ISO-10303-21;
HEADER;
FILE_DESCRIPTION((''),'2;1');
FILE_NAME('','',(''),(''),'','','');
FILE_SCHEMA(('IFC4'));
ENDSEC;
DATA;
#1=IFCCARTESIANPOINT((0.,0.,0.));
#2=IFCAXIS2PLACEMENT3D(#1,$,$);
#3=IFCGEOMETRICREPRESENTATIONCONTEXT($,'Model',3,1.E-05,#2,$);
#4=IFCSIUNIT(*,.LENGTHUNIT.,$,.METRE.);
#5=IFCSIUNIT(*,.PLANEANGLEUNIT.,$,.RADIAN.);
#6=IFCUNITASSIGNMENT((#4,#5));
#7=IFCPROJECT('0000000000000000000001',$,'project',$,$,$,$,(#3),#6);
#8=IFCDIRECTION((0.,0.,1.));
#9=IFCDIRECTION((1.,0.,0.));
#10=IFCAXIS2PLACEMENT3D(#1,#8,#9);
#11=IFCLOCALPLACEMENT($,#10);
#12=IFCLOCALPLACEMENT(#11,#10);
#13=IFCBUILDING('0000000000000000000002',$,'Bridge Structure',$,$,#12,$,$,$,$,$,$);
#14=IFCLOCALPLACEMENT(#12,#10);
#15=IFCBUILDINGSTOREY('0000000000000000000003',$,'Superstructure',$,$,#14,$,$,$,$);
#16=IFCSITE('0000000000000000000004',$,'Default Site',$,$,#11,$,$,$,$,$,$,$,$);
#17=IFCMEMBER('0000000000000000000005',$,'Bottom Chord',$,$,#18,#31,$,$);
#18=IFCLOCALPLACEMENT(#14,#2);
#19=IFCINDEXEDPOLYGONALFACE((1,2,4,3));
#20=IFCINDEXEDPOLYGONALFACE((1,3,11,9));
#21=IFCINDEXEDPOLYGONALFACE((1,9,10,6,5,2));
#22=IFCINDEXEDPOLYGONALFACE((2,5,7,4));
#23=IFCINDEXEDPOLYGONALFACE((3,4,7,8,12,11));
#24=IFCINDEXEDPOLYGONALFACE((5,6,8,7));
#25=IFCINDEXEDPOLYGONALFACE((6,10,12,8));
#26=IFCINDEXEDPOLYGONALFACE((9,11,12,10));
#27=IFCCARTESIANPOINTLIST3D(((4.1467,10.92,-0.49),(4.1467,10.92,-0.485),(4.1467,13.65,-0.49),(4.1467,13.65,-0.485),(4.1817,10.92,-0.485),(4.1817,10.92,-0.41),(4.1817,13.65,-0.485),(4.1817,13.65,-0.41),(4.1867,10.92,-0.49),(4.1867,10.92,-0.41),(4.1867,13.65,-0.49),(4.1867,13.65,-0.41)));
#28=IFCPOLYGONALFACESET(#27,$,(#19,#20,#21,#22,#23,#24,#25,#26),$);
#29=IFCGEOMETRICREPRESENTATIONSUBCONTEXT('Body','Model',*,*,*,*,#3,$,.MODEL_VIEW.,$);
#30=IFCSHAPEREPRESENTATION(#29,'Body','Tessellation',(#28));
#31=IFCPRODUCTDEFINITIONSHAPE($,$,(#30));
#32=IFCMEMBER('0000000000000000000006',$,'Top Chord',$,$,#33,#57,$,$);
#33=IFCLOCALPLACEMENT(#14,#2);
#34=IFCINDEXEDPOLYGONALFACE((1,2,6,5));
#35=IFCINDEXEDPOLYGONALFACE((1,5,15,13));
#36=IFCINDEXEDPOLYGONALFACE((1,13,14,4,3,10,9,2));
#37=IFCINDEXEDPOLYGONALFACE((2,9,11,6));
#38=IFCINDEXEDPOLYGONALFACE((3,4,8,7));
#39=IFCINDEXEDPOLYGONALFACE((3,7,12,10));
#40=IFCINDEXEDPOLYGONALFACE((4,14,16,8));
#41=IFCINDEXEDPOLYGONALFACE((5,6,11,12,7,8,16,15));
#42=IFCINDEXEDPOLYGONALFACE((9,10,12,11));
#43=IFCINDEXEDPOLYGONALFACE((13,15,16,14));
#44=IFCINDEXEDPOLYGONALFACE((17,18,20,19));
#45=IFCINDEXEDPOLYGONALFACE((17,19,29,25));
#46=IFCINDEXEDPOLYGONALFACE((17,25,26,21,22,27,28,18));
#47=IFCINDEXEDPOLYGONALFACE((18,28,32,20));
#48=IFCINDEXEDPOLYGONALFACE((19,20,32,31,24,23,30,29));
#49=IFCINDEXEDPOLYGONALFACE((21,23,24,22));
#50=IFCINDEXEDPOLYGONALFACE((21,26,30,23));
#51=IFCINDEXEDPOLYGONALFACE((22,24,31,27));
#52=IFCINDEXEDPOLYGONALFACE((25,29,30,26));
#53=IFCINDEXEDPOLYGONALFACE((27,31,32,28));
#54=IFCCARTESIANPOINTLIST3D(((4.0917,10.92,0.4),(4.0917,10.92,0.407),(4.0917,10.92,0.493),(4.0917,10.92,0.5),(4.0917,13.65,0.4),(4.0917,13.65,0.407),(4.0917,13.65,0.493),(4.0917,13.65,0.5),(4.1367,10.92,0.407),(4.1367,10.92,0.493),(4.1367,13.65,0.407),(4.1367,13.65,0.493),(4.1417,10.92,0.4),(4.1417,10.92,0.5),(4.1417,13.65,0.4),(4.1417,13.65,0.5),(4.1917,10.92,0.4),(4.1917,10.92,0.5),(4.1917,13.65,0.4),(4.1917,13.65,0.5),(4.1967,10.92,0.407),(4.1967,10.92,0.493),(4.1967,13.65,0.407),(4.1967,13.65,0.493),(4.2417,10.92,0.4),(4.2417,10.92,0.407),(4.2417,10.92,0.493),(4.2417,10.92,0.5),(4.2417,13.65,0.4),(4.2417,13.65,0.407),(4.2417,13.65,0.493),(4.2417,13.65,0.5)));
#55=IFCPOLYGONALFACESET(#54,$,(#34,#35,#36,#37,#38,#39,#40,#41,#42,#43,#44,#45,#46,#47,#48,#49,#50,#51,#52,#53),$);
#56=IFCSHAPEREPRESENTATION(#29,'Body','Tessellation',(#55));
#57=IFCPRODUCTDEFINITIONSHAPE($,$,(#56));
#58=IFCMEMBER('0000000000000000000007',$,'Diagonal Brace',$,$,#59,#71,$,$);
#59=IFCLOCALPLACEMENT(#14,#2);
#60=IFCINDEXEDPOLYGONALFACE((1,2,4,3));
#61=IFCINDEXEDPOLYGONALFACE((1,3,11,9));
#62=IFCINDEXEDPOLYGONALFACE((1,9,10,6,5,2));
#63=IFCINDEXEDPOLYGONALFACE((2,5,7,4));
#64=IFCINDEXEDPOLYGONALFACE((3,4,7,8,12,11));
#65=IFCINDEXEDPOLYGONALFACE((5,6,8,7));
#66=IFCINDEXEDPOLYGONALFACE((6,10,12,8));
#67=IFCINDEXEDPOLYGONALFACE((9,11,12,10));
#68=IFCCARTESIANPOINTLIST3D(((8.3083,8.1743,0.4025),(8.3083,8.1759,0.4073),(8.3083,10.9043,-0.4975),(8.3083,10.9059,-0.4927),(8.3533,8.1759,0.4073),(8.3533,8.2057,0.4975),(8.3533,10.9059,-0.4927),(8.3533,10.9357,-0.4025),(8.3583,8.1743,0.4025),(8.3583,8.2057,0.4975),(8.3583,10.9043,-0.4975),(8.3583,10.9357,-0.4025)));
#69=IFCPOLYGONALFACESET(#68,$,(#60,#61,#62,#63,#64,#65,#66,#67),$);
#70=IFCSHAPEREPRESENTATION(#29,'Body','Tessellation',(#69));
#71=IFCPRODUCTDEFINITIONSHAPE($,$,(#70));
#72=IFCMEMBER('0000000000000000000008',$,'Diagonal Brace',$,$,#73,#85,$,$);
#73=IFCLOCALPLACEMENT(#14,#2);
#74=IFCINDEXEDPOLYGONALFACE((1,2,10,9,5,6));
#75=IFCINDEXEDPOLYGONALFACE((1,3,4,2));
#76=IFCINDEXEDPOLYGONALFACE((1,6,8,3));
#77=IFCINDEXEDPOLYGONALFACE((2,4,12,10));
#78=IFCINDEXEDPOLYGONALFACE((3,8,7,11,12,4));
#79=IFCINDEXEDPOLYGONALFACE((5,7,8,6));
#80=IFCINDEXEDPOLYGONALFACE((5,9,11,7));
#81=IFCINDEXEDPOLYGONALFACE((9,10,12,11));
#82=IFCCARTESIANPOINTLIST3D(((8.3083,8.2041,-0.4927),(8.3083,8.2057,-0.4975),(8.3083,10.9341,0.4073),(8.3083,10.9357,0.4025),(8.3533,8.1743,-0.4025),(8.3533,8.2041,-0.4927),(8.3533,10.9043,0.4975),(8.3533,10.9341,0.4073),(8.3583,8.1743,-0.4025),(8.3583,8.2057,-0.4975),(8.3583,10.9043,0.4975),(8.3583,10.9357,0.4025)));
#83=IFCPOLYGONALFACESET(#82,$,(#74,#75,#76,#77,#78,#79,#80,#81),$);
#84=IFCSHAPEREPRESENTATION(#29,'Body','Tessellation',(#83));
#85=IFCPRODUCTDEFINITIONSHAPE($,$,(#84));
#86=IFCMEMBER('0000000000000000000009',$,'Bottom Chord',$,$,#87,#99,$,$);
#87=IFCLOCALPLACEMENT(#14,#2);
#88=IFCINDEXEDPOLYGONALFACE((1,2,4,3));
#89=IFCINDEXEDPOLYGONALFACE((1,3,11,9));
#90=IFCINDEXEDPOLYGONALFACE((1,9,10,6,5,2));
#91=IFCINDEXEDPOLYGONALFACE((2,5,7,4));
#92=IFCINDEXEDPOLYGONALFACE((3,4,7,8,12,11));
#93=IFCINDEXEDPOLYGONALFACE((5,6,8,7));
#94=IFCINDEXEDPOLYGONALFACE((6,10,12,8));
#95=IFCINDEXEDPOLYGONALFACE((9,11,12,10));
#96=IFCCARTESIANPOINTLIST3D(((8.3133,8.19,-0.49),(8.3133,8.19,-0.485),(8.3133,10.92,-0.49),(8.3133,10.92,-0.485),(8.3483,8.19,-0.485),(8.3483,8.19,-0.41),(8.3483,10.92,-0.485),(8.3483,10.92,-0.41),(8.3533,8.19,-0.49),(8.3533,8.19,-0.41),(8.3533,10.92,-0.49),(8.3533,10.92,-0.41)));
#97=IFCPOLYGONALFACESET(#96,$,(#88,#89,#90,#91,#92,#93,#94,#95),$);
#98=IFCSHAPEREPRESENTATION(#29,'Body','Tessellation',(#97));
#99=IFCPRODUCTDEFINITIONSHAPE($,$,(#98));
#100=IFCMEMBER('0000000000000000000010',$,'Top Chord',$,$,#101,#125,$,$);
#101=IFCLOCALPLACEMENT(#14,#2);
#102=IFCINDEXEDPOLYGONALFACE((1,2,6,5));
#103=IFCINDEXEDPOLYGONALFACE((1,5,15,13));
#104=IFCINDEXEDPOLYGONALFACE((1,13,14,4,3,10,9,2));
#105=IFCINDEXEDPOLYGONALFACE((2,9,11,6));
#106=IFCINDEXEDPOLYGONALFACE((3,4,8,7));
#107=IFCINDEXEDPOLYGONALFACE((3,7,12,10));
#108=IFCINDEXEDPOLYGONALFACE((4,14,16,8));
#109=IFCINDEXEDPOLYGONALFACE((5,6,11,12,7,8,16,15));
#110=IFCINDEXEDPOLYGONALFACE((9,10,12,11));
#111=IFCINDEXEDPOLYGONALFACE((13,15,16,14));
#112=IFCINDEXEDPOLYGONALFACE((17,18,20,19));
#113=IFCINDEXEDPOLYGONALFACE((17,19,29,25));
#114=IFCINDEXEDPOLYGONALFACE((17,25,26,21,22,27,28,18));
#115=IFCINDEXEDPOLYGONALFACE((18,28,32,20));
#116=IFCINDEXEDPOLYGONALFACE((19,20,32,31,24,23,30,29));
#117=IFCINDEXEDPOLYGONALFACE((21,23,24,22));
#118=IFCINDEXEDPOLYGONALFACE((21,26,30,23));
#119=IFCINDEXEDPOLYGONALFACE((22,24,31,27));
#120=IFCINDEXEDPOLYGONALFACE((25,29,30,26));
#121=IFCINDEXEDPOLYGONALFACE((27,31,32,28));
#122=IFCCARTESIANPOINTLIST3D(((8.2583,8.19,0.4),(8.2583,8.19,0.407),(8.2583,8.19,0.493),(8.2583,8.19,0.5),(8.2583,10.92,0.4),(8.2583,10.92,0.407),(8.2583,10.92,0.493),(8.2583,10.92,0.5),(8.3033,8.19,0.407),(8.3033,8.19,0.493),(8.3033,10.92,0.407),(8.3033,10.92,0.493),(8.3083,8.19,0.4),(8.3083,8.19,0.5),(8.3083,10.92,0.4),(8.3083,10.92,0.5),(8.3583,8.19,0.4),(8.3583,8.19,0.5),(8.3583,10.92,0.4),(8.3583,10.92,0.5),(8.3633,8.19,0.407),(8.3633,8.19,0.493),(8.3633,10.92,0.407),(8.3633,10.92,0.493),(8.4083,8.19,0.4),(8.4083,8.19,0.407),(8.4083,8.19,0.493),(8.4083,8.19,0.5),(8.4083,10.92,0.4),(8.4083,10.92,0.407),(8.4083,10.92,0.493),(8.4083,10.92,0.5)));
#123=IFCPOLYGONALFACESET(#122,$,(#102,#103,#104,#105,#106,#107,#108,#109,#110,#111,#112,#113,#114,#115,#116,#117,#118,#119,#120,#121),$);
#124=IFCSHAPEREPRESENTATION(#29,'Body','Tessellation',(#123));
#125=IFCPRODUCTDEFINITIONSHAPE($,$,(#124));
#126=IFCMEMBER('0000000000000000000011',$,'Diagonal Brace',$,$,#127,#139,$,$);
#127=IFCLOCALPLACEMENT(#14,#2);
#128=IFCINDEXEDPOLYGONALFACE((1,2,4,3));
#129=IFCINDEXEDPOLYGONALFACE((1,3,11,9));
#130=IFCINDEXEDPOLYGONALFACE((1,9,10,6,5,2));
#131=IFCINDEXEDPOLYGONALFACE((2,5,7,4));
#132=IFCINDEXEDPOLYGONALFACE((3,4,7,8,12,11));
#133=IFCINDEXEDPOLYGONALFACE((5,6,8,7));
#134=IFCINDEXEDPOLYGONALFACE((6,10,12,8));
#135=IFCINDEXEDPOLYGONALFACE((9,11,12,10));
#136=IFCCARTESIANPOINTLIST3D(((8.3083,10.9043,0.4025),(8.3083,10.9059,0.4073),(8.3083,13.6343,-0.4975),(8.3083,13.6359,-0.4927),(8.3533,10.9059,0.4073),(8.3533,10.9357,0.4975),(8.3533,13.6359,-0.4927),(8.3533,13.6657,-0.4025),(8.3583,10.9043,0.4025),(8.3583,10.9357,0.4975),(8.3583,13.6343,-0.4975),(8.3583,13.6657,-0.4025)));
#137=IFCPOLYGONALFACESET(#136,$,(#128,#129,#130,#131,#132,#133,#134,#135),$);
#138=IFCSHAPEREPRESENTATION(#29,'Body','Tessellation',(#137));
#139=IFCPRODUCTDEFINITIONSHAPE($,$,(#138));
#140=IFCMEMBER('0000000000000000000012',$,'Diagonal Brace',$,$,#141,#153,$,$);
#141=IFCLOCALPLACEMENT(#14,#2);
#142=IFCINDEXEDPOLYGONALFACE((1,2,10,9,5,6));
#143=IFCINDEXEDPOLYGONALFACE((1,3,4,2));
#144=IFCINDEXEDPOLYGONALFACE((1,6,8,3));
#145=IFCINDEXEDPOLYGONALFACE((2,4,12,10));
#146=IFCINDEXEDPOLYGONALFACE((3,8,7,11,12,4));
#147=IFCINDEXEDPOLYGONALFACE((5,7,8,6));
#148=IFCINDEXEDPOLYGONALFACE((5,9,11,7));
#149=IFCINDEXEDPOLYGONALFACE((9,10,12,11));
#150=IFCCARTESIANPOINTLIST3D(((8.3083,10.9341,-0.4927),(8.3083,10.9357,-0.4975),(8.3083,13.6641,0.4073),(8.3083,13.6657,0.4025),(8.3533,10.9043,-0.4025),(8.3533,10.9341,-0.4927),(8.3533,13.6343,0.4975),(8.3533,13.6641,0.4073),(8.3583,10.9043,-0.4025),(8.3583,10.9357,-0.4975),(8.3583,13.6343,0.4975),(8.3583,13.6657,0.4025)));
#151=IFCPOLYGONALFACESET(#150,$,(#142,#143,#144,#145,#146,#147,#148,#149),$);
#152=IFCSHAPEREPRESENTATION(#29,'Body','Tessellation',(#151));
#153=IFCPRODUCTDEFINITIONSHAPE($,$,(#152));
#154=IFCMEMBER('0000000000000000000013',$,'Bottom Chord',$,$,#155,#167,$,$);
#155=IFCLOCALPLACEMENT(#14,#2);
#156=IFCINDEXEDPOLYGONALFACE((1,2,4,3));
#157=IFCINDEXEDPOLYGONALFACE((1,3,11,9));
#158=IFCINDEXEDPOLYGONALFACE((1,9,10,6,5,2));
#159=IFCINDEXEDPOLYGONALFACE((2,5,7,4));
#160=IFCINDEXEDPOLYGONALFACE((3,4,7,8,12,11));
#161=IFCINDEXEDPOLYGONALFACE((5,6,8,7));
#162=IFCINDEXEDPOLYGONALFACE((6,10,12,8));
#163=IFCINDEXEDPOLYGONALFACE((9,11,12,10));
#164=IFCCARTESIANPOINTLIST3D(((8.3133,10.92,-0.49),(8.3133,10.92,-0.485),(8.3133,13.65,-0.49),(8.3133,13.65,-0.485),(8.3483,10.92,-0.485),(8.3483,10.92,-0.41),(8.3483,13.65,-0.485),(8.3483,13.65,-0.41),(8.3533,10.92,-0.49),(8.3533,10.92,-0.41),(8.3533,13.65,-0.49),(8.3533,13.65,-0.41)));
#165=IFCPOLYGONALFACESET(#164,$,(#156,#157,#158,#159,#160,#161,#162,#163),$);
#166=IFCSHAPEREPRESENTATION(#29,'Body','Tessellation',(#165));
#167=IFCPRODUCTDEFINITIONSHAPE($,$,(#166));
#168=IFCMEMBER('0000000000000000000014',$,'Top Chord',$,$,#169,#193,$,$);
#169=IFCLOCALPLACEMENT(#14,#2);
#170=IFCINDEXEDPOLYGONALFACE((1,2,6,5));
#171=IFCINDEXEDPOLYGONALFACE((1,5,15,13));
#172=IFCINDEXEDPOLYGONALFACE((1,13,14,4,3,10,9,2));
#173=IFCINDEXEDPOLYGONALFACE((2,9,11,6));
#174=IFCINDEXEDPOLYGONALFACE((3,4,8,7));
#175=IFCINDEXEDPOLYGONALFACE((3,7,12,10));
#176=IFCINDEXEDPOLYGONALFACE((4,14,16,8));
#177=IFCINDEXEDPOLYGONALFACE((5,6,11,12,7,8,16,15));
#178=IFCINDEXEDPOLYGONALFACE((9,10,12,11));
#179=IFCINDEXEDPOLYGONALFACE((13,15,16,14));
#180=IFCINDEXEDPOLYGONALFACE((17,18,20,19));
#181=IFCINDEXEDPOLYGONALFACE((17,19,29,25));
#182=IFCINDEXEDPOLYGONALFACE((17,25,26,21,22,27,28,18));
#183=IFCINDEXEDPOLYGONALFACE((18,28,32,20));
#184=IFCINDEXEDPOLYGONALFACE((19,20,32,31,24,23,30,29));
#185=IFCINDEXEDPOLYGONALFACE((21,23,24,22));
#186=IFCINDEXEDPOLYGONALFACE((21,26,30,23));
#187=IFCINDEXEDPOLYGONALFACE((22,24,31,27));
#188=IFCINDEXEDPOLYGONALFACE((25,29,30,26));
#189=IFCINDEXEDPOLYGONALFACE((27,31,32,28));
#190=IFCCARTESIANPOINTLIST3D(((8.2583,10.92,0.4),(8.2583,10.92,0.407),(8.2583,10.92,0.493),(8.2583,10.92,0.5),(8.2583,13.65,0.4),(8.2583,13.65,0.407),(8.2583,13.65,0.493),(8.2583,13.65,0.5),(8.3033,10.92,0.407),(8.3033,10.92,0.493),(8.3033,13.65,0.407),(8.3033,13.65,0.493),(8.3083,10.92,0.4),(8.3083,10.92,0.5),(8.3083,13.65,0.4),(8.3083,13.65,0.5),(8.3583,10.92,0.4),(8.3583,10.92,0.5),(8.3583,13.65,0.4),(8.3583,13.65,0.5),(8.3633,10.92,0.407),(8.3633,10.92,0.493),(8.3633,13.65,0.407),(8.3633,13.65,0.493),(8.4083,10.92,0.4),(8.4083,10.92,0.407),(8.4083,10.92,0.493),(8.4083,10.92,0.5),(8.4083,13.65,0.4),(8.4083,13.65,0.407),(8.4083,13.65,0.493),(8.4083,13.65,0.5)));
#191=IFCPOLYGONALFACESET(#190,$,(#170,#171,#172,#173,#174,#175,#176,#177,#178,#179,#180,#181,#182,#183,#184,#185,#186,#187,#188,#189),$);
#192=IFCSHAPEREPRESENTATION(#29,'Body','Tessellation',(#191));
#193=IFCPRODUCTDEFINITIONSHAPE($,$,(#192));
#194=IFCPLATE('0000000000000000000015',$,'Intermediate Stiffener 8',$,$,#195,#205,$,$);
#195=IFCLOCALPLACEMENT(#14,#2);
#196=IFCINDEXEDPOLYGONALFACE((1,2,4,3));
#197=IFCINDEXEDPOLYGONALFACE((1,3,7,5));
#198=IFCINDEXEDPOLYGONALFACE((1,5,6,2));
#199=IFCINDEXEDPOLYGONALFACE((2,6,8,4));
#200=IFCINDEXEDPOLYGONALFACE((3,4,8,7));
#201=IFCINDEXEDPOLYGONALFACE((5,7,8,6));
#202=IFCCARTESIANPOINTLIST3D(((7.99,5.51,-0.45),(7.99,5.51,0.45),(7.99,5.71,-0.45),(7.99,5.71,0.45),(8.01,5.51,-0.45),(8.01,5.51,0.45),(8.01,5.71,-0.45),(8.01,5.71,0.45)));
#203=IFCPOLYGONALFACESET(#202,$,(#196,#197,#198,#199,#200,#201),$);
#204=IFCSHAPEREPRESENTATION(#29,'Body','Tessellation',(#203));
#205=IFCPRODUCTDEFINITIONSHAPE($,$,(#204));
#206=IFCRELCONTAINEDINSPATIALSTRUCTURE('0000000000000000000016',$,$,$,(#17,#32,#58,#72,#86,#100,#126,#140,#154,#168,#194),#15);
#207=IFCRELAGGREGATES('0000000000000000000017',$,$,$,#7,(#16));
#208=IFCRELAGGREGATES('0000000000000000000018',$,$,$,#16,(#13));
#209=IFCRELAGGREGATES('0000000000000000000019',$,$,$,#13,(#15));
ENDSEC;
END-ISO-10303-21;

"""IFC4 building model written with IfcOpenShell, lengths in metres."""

from ifc_helpers import new_model, si_unit, frame, origin, origin_with_axes, origin_2d_with_axis, place, context, subcontext, project, spatial, polyline, rectangle, l_section, outline, composite_profile, extrude, element, save


model = new_model("IFC4")

# Units and contexts
model_context = context("Model", 3, precision=1e-05, world=origin())
body_context = subcontext(model_context, "Body", "Model", "MODEL_VIEW")
ifc_project = project(units=[si_unit("LENGTHUNIT", "METRE"), si_unit("PLANEANGLEUNIT", "RADIAN")], contexts=[model_context])

# Site, building, storey
site_placement = place(None, origin_with_axes())
site = spatial("IfcSite", under=ifc_project, at=site_placement, Name="Default Site")
building_placement = place(site_placement, origin_with_axes())
building = spatial("IfcBuilding", under=site, at=building_placement, Name="Bridge Structure")
storey_placement = place(building_placement, origin_with_axes())
storey = spatial("IfcBuildingStorey", under=building, at=storey_placement, Name="Superstructure")

# Members
member_1_placement = place(storey_placement, frame((4.1667, 10.92, -0.45), z_axis=(0.0, 1.0, 0.0), x_axis=(-1.0, 0.0, 0.0)))
element("IfcMember", 1, at=member_1_placement, inside=storey, Name="Bottom Chord", context=body_context, shape_type="SweptSolid", body=[
    extrude(l_section(Depth=0.08, Width=0.04, Thickness=0.005, at=origin_2d_with_axis()), origin_with_axes(), (0.0, 0.0, 1.0), 2.73),
])
member_2_placement = place(storey_placement, frame((4.1667, 10.92, 0.45), z_axis=(0.0, 1.0, 0.0), x_axis=(-1.0, 0.0, 0.0)))
element("IfcMember", 2, at=member_2_placement, inside=storey, Name="Top Chord", context=body_context, shape_type="SweptSolid", body=[
    extrude(composite_profile([outline(polyline([(-0.025, -0.05), (-0.025, 0.05), (-0.075, 0.05), (-0.075, 0.043), (-0.03, 0.043), (-0.03, -0.043), (-0.075, -0.043), (-0.075, -0.05), (-0.025, -0.05)])), outline(polyline([(0.025, -0.05), (0.075, -0.05), (0.075, -0.043), (0.03, -0.043), (0.03, 0.043), (0.075, 0.043), (0.075, 0.05), (0.025, 0.05), (0.025, -0.05)]))]), origin_with_axes(), (0.0, 0.0, 1.0), 2.73),
])
for number, where, z_axis, x_axis, name in (
    (3, (8.3333, 8.19, 0.45), (0.0, 0.949722, -0.313095), (-1.0, 0.0, 0.0), "Diagonal Brace"),
    (4, (8.3333, 8.19, -0.45), (0.0, 0.949722, 0.313095), (-1.0, 0.0, 0.0), "Diagonal Brace"),
):
    element("IfcMember", number, at=place(storey_placement, frame(where, z_axis=z_axis, x_axis=x_axis)), inside=storey, Name=name, context=body_context, shape_type="SweptSolid", body=[
        extrude(l_section(Depth=0.1, Width=0.05, Thickness=0.005, at=origin_2d_with_axis()), origin_with_axes(), (0.0, 0.0, 1.0), 2.8745),
    ])
member_3_placement = place(storey_placement, frame((8.3333, 8.19, -0.45), z_axis=(0.0, 1.0, 0.0), x_axis=(-1.0, 0.0, 0.0)))
element("IfcMember", 5, at=member_3_placement, inside=storey, Name="Bottom Chord", context=body_context, shape_type="SweptSolid", body=[
    extrude(l_section(Depth=0.08, Width=0.04, Thickness=0.005, at=origin_2d_with_axis()), origin_with_axes(), (0.0, 0.0, 1.0), 2.73),
])
member_4_placement = place(storey_placement, frame((8.3333, 8.19, 0.45), z_axis=(0.0, 1.0, 0.0), x_axis=(-1.0, 0.0, 0.0)))
element("IfcMember", 6, at=member_4_placement, inside=storey, Name="Top Chord", context=body_context, shape_type="SweptSolid", body=[
    extrude(composite_profile([outline(polyline([(-0.025, -0.05), (-0.025, 0.05), (-0.075, 0.05), (-0.075, 0.043), (-0.03, 0.043), (-0.03, -0.043), (-0.075, -0.043), (-0.075, -0.05), (-0.025, -0.05)])), outline(polyline([(0.025, -0.05), (0.075, -0.05), (0.075, -0.043), (0.03, -0.043), (0.03, 0.043), (0.075, 0.043), (0.075, 0.05), (0.025, 0.05), (0.025, -0.05)]))]), origin_with_axes(), (0.0, 0.0, 1.0), 2.73),
])
for number, where, z_axis, x_axis, name in (
    (7, (8.3333, 10.92, 0.45), (0.0, 0.949722, -0.313095), (-1.0, 0.0, 0.0), "Diagonal Brace"),
    (8, (8.3333, 10.92, -0.45), (0.0, 0.949722, 0.313095), (-1.0, 0.0, 0.0), "Diagonal Brace"),
):
    element("IfcMember", number, at=place(storey_placement, frame(where, z_axis=z_axis, x_axis=x_axis)), inside=storey, Name=name, context=body_context, shape_type="SweptSolid", body=[
        extrude(l_section(Depth=0.1, Width=0.05, Thickness=0.005, at=origin_2d_with_axis()), origin_with_axes(), (0.0, 0.0, 1.0), 2.8745),
    ])
member_5_placement = place(storey_placement, frame((8.3333, 10.92, -0.45), z_axis=(0.0, 1.0, 0.0), x_axis=(-1.0, 0.0, 0.0)))
element("IfcMember", 9, at=member_5_placement, inside=storey, Name="Bottom Chord", context=body_context, shape_type="SweptSolid", body=[
    extrude(l_section(Depth=0.08, Width=0.04, Thickness=0.005, at=origin_2d_with_axis()), origin_with_axes(), (0.0, 0.0, 1.0), 2.73),
])
member_6_placement = place(storey_placement, frame((8.3333, 10.92, 0.45), z_axis=(0.0, 1.0, 0.0), x_axis=(-1.0, 0.0, 0.0)))
element("IfcMember", 10, at=member_6_placement, inside=storey, Name="Top Chord", context=body_context, shape_type="SweptSolid", body=[
    extrude(composite_profile([outline(polyline([(-0.025, -0.05), (-0.025, 0.05), (-0.075, 0.05), (-0.075, 0.043), (-0.03, 0.043), (-0.03, -0.043), (-0.075, -0.043), (-0.075, -0.05), (-0.025, -0.05)])), outline(polyline([(0.025, -0.05), (0.075, -0.05), (0.075, -0.043), (0.03, -0.043), (0.03, 0.043), (0.075, 0.043), (0.075, 0.05), (0.025, 0.05), (0.025, -0.05)]))]), origin_with_axes(), (0.0, 0.0, 1.0), 2.73),
])

# Plate
for number, where, z_axis, x_axis, name in (
    (11, (8.0, 5.61, -0.45), (0.0, 0.0, 1.0), (1.0, 0.0, 0.0), "Intermediate Stiffener 8"),
):
    element("IfcPlate", number, at=place(storey_placement, frame(where, z_axis=z_axis, x_axis=x_axis)), inside=storey, Name=name, context=body_context, shape_type="SweptSolid", body=[
        extrude(rectangle(XDim=0.02, YDim=0.2, at=origin_2d_with_axis()), origin_with_axes(), (0.0, 0.0, 1.0), 0.9),
    ])

save(model, "model.ifc")
